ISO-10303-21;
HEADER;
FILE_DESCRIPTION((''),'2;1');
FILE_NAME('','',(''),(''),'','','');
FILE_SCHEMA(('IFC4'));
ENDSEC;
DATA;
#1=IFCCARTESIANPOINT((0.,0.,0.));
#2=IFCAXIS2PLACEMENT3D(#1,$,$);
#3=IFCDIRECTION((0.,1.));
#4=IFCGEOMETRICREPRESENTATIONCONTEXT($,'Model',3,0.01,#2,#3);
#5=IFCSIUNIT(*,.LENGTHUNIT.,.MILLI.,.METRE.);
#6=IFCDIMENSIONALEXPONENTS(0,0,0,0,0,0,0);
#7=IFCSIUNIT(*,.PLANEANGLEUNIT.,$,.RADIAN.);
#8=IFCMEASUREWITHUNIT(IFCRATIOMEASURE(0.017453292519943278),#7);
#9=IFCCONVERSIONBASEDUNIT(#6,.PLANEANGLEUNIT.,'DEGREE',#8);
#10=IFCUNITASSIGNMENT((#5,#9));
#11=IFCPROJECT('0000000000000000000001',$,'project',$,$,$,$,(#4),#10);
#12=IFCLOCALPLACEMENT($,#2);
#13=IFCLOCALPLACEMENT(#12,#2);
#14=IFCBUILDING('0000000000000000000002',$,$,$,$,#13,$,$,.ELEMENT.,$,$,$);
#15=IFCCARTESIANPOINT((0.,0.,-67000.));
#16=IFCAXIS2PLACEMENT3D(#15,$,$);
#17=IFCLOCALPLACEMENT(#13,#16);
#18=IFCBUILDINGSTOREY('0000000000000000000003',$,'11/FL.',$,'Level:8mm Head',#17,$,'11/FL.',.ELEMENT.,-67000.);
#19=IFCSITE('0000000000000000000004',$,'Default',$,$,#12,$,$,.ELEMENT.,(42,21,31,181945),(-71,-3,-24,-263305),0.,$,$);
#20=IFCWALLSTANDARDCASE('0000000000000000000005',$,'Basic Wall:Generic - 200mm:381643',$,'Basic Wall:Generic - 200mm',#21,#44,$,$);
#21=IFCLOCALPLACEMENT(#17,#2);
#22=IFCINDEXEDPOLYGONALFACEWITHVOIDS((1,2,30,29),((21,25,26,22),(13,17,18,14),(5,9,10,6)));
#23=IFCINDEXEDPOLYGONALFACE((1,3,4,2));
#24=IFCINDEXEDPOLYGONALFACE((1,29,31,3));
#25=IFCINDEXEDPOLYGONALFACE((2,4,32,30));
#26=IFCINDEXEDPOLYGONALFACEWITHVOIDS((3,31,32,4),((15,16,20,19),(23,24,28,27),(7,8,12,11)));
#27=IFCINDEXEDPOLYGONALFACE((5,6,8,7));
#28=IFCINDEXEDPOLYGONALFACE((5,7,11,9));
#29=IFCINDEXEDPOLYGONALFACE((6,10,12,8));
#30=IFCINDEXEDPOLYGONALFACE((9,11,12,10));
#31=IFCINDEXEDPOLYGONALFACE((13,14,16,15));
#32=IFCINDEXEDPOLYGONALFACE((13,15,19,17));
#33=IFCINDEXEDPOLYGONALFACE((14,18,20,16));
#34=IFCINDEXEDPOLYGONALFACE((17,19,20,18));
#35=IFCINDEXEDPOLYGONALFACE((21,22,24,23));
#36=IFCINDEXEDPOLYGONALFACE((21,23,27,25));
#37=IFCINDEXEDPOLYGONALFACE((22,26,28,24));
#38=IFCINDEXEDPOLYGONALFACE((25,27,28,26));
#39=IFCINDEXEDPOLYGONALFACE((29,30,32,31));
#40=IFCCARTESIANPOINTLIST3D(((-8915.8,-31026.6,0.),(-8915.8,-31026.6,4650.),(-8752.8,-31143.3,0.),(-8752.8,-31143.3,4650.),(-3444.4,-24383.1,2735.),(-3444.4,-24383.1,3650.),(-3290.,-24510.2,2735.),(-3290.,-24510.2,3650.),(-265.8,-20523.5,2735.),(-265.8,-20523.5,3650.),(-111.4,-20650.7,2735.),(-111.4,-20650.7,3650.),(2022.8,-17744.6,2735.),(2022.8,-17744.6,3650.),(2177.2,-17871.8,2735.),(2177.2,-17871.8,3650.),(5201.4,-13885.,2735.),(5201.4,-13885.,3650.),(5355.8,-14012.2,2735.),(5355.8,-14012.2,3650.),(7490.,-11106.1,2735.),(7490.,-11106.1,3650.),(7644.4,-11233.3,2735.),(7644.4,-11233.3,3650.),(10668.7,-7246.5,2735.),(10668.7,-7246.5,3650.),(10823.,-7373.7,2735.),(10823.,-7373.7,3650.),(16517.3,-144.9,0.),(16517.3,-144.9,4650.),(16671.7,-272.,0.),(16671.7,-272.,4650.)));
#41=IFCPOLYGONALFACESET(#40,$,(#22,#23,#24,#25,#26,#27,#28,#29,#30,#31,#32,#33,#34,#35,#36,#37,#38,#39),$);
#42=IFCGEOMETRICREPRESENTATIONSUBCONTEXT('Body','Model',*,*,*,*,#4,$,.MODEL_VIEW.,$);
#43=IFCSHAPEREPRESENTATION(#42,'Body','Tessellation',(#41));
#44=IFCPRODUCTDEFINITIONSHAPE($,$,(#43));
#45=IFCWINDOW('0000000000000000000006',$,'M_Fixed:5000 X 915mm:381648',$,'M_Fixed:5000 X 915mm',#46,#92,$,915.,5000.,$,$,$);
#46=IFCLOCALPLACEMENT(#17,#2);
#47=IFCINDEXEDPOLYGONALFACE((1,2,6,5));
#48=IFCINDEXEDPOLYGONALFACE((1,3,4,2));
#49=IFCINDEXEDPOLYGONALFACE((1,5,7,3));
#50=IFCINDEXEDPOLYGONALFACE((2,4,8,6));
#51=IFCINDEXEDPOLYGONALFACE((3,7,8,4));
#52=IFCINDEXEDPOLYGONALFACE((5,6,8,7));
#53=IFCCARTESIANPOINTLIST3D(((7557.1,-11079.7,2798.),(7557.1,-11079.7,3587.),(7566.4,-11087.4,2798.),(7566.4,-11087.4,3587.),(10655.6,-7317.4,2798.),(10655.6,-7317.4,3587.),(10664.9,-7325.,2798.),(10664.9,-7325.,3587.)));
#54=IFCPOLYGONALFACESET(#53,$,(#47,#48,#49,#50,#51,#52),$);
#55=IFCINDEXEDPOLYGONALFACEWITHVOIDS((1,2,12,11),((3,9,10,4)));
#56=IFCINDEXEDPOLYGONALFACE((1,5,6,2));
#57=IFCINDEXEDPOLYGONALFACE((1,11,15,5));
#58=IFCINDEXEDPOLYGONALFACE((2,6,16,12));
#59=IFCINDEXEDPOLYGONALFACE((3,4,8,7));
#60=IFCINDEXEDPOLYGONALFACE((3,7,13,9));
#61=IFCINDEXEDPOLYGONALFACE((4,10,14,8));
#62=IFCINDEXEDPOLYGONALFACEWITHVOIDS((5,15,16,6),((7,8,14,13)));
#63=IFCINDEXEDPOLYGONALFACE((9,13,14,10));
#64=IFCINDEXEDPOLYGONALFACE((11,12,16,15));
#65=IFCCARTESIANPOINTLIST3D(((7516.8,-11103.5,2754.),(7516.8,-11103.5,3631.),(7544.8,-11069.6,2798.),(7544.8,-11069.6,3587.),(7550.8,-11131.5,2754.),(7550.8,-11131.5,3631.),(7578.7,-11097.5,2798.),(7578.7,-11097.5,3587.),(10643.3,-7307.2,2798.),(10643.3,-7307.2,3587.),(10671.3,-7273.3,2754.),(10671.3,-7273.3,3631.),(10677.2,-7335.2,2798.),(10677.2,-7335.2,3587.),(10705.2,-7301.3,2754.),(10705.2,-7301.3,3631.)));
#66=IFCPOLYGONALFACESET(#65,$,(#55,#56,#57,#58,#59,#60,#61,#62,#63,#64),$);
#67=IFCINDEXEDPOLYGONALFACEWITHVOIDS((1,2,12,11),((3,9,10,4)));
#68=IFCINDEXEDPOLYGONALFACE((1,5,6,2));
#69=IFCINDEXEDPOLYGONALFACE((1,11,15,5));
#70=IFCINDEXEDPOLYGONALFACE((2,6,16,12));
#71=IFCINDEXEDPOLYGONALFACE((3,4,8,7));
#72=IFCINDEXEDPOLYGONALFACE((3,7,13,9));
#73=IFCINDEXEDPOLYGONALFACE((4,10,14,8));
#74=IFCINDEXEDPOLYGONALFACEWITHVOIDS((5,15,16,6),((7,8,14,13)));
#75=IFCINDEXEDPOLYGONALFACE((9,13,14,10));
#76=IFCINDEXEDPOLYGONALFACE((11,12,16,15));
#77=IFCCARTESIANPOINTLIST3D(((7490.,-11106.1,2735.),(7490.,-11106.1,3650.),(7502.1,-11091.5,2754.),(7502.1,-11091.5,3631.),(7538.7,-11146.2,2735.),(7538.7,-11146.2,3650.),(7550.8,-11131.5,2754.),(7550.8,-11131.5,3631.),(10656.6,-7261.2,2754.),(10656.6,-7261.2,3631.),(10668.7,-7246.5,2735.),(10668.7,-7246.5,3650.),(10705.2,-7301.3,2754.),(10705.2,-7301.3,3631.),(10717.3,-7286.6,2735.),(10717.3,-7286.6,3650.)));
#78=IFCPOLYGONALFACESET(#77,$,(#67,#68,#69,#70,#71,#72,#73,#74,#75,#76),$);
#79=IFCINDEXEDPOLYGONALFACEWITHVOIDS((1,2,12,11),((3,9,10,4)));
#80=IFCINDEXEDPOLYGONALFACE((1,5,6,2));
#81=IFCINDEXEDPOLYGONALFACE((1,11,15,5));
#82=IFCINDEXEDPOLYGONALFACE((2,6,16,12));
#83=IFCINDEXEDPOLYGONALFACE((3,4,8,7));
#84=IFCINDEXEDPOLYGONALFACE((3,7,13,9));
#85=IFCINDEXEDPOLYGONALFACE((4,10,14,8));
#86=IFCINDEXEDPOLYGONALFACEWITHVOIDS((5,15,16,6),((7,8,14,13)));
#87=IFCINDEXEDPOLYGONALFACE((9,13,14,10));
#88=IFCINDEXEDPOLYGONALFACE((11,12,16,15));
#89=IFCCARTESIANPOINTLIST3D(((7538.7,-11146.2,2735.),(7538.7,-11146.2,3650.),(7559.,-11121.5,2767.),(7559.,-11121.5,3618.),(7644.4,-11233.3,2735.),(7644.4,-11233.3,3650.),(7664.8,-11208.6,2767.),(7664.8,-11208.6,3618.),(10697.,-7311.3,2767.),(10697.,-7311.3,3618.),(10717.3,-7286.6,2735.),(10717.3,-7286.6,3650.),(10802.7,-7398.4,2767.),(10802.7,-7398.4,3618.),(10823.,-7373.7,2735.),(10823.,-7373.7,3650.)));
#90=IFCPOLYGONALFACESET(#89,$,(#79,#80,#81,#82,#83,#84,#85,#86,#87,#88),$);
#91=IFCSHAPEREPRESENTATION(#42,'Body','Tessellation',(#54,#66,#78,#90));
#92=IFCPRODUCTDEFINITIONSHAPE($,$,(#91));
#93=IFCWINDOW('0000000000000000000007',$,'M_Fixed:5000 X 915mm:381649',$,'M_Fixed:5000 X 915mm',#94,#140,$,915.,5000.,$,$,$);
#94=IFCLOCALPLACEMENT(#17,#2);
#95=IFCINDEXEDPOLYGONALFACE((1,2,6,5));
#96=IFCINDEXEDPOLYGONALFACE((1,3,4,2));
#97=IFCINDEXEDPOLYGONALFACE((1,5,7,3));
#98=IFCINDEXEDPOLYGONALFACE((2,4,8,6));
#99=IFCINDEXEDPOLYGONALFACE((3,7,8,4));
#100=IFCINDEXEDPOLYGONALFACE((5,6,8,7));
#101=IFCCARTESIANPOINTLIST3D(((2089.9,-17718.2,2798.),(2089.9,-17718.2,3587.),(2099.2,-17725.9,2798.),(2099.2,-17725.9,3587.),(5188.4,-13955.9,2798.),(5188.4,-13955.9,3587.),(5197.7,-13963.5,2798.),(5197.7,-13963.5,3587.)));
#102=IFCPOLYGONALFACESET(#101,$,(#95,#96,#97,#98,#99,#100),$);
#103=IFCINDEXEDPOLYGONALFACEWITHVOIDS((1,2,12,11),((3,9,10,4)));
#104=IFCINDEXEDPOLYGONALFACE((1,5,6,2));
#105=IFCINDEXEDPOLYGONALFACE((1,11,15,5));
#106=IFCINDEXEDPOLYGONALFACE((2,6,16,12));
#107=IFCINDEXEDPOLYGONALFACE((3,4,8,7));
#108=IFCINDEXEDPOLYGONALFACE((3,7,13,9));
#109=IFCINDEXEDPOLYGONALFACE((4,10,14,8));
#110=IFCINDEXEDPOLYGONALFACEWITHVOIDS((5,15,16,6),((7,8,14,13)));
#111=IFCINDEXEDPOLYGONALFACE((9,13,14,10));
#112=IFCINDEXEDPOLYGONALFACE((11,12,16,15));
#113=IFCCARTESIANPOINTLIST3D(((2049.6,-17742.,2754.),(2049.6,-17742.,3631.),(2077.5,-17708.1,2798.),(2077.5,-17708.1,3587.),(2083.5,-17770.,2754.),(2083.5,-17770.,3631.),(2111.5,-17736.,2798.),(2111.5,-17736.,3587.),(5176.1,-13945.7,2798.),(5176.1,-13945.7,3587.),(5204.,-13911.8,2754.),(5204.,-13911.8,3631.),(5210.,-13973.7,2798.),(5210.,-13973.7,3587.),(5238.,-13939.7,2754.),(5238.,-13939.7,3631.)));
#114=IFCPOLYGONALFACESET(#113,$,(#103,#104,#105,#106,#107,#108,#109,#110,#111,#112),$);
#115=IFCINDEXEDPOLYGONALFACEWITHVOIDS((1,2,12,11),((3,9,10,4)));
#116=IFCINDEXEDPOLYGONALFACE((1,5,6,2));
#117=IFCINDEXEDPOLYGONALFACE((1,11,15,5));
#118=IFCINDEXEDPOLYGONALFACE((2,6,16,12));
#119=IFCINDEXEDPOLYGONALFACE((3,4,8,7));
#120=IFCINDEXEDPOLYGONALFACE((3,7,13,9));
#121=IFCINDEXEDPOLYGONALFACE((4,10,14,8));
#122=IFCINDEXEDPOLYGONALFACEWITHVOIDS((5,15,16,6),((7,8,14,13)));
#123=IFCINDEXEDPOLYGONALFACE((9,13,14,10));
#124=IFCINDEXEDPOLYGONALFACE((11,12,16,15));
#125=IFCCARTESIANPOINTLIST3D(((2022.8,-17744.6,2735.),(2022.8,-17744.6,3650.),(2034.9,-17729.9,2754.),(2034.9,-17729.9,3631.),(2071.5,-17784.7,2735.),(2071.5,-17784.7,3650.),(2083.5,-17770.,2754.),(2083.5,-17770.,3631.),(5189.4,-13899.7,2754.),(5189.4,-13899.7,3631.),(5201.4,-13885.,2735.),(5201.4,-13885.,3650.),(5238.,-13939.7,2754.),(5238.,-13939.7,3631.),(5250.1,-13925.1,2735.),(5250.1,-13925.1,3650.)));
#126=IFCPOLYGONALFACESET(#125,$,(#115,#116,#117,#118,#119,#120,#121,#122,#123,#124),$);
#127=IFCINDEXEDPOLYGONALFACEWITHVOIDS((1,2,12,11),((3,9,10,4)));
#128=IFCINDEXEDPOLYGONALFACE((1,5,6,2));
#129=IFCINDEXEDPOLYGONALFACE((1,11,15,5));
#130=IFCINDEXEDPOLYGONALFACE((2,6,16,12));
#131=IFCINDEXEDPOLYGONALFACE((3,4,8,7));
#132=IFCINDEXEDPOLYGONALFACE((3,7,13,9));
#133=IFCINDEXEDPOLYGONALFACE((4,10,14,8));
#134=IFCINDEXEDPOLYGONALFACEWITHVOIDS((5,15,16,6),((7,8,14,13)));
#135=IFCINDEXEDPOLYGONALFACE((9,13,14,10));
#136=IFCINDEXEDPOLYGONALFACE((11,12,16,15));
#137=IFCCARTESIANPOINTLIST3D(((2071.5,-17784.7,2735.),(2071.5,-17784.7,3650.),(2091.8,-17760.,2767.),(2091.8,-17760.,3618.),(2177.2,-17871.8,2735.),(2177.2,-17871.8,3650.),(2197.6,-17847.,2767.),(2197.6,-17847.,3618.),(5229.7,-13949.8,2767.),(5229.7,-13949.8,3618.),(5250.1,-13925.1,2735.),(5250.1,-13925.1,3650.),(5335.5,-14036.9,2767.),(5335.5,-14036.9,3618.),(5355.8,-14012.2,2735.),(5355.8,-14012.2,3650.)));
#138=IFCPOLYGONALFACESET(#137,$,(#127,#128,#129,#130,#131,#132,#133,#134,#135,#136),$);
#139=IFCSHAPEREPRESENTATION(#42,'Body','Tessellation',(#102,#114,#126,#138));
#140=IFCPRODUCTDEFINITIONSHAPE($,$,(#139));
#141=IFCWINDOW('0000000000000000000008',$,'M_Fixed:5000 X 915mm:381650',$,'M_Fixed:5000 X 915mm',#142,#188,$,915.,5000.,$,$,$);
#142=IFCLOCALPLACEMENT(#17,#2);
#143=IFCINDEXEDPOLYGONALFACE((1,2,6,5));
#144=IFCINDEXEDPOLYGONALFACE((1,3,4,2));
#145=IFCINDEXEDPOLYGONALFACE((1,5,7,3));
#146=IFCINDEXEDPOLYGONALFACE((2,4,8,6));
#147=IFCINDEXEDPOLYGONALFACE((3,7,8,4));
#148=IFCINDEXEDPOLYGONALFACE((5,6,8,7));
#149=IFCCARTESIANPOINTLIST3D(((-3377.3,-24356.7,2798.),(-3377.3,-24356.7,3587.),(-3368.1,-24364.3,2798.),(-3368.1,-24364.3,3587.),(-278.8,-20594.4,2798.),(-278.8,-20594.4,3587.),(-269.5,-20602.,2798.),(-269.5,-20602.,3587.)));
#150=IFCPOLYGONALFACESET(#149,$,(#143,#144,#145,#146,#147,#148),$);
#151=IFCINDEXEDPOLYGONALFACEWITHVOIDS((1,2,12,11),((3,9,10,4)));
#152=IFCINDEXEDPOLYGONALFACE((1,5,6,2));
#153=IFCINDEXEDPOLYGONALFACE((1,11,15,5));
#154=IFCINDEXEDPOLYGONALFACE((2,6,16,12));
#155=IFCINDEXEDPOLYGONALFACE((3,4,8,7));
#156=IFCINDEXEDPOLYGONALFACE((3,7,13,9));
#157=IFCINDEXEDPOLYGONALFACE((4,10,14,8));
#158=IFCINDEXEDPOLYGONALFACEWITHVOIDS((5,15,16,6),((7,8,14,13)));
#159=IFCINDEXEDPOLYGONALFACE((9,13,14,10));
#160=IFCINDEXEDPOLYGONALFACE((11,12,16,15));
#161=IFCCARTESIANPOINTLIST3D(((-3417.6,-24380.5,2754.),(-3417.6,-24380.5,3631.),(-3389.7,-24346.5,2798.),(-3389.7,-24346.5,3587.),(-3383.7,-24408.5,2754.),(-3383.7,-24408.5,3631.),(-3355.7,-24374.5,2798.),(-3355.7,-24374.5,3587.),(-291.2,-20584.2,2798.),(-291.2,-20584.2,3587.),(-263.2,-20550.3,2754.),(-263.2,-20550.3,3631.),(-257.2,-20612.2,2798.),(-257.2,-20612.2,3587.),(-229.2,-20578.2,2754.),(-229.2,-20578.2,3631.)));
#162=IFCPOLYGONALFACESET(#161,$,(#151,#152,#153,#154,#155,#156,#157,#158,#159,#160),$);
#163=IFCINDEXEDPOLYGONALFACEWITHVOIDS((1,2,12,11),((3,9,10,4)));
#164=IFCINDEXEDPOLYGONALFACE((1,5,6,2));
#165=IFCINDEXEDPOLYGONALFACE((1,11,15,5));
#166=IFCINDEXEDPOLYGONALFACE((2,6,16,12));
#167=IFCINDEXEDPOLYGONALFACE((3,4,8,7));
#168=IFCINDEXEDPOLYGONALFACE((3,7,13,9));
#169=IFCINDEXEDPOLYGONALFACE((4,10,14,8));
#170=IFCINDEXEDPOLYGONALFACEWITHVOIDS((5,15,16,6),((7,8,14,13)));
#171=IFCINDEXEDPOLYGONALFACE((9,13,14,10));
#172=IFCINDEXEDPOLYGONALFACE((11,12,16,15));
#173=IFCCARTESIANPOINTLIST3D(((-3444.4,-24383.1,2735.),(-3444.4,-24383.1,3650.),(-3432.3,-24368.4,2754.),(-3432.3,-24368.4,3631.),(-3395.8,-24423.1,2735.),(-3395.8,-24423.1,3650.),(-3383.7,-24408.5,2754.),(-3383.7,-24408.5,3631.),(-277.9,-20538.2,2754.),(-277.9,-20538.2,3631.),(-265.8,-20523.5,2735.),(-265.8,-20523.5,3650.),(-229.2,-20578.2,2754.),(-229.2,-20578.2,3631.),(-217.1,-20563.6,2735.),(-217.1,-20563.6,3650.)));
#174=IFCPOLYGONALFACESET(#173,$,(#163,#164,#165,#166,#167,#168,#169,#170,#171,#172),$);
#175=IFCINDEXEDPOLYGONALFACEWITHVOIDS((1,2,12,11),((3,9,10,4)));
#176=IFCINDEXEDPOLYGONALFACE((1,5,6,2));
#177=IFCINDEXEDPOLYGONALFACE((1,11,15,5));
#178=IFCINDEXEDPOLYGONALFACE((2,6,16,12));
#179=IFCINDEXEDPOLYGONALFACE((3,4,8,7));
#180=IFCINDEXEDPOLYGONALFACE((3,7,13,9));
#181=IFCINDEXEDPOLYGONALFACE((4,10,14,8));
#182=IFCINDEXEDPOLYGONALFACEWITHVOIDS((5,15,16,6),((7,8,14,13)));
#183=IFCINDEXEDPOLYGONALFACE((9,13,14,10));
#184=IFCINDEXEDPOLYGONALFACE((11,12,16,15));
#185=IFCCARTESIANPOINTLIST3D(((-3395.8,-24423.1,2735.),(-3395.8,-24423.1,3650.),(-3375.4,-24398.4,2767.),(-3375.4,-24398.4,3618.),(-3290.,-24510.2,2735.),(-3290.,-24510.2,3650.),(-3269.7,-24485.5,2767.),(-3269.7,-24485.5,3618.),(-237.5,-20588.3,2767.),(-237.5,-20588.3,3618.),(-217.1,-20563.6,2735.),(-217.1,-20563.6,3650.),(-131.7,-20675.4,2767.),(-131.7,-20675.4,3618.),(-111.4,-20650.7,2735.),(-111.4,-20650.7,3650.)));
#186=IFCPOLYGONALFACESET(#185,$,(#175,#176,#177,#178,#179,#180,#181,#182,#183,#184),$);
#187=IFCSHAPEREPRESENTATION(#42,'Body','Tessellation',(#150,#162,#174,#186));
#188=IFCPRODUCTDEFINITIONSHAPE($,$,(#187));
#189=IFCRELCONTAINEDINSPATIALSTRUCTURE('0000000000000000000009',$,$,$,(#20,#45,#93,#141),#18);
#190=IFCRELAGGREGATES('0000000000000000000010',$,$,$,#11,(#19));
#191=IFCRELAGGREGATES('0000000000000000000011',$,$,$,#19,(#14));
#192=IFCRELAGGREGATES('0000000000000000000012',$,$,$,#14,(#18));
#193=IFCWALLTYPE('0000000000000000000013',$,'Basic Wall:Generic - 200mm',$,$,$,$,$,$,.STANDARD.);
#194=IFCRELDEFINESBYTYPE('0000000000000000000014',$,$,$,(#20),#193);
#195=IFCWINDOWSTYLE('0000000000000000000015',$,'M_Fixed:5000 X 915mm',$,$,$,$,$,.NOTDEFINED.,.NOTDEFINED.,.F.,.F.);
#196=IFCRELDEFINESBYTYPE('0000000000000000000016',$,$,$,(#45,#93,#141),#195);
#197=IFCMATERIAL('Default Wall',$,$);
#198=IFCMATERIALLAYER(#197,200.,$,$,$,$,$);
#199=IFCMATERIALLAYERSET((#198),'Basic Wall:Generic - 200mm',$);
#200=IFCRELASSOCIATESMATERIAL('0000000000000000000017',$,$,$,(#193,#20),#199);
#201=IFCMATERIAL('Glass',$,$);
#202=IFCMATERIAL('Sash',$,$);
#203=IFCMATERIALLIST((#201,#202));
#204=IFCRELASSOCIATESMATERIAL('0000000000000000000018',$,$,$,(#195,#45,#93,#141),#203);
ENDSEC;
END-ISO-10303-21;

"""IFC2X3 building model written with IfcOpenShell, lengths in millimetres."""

from ifc_helpers import new_model, entity, si_unit, converted_unit, direction, frame, frame_2d, origin, place, context, subcontext, project, spatial, polyline, rectangle, outline, extrude, source, transform, mapped, material, material_list, layer, layer_set, layer_usage, type_object, type_shapes, element, fill, save


model = new_model("IFC2X3")

# Units and contexts
model_context = context("Model", 3, precision=0.01, world=origin(), true_north=direction((0.0, 1.0)))
body_context = subcontext(model_context, "Body", "Model", "MODEL_VIEW")
ifc_project = project(units=[si_unit("LENGTHUNIT", "METRE", prefix="MILLI"), converted_unit("PLANEANGLEUNIT", "DEGREE", entity("IfcRatioMeasure", 0.017453292519943278), si_unit("PLANEANGLEUNIT", "RADIAN"), dimensions=[0, 0, 0, 0, 0, 0, 0])], contexts=[model_context])

# Site, building, storey
site_placement = place(None, origin())
site = spatial("IfcSite", under=ifc_project, at=site_placement, Name="Default", CompositionType="ELEMENT", RefLatitude=(42, 21, 31, 181945), RefLongitude=(-71, -3, -24, -263305), RefElevation=0.0)
building_placement = place(site_placement, origin())
building = spatial("IfcBuilding", under=site, at=building_placement, CompositionType="ELEMENT")
storey_placement = place(building_placement, frame((0.0, 0.0, -67000.0)))
storey = spatial("IfcBuildingStorey", under=building, at=storey_placement, Name="11/FL.", ObjectType="Level:8mm Head", LongName="11/FL.", CompositionType="ELEMENT", Elevation=-67000.0)

# Shared definitions
ifc_material_1 = material(Name="Default Wall")
ifc_layer = layer(ifc_material_1, 200.0)
ifc_layer_set = layer_set([ifc_layer], Name="Basic Wall:Generic - 200mm")
ifc_layer_usage = layer_usage(ifc_layer_set, "AXIS2", "NEGATIVE", 100.0)
wall_type = type_object("IfcWallType", Name="Basic Wall:Generic - 200mm", PredefinedType="STANDARD", material=ifc_layer_set)

# Wall, openings, windows
wall_1_placement = place(storey_placement, frame((17103.1, 409.1, 0.0), z_axis=(0.0, 0.0, 1.0), x_axis=(-0.635723, -0.771917, 0.0)))
wall_1 = element("IfcWallStandardCase", 1, at=wall_1_placement, inside=storey, type_object=wall_type, material=ifc_layer_usage, Name="Basic Wall:Generic - 200mm:381643", ObjectType="Basic Wall:Generic - 200mm", context=body_context, shape_type="SweptSolid", body=[
    extrude(outline(polyline([(40806.5, -100.0), (40793.0, 100.0), (37219.3, 100.0), (37019.3, 100.0), (800.0, 100.0), (800.0, -100.0), (37019.3, -100.0), (37219.3, -100.0), (40806.5, -100.0)])), origin(), (0.0, 0.0, 1.0), 4650.0),
])
opening_1_placement = place(wall_1_placement, origin())
element("IfcOpeningElement", 2, at=opening_1_placement, cuts=wall_1, ObjectType="Opening", context=body_context, shape_type="SweptSolid", body=[
    extrude(rectangle(XDim=1000.0, YDim=1012.7, at=frame_2d((0.0, 0.0), x_axis=(1.0, 0.0))), frame((293.7, -183.3, 500.0), z_axis=(0.0, 1.0, 0.0), x_axis=(0.0, 0.0, -1.0)), (0.0, 0.0, 1.0), 1010.1),
])
opening_2_placement = place(wall_1_placement, frame((15000.0, 100.0, 2735.0)))
opening_2 = element("IfcOpeningElement", 3, at=opening_2_placement, cuts=wall_1, ObjectType="Opening", context=body_context, shape_type="SweptSolid", body=[
    extrude(rectangle(XDim=915.0, YDim=5000.0, at=frame_2d((457.5, 2500.0), x_axis=(1.0, 0.0))), frame((0.0, 0.0, 0.0), z_axis=(0.0, -1.0, 0.0), x_axis=(0.0, 0.0, 1.0)), (0.0, 0.0, 1.0), 200.0),
])
opening_3_placement = place(wall_1_placement, frame((23600.0, 100.0, 2735.0)))
opening_3 = element("IfcOpeningElement", 4, at=opening_3_placement, cuts=wall_1, ObjectType="Opening", context=body_context, shape_type="SweptSolid", body=[
    extrude(rectangle(XDim=915.0, YDim=5000.0, at=frame_2d((457.5, 2500.0), x_axis=(1.0, 0.0))), frame((0.0, 0.0, 0.0), z_axis=(0.0, -1.0, 0.0), x_axis=(0.0, 0.0, 1.0)), (0.0, 0.0, 1.0), 200.0),
])
opening_4_placement = place(wall_1_placement, frame((32200.0, 100.0, 2735.0)))
opening_4 = element("IfcOpeningElement", 5, at=opening_4_placement, cuts=wall_1, ObjectType="Opening", context=body_context, shape_type="SweptSolid", body=[
    extrude(rectangle(XDim=915.0, YDim=5000.0, at=frame_2d((457.5, 2500.0), x_axis=(1.0, 0.0))), frame((0.0, 0.0, 0.0), z_axis=(0.0, -1.0, 0.0), x_axis=(0.0, 0.0, 1.0)), (0.0, 0.0, 1.0), 200.0),
])
ifc_material_2 = material(Name="Glass")
ifc_material_3 = material(Name="Sash")
ifc_material_list = material_list([ifc_material_2, ifc_material_3])
window_style_1 = type_object("IfcWindowStyle", Name="M_Fixed:5000 X 915mm", ConstructionType="NOTDEFINED", OperationType="NOTDEFINED", ParameterTakesPrecedence=False, Sizeable=False, material=ifc_material_list)
shared_shape_1 = source(origin(), body_context, "Body", "SweptSolid", [
    extrude(rectangle(XDim=12.0, YDim=4874.0, at=frame_2d((0.0, 0.0), x_axis=(1.0, 0.0))), frame((2500.0, 159.0, 63.0), z_axis=(0.0, 0.0, 1.0), x_axis=(0.0, -1.0, 0.0)), (0.0, 0.0, 1.0), 789.0),
    extrude(outline(polyline([(-2481.0, -438.5), (2481.0, -438.5), (2481.0, 438.5), (-2481.0, 438.5), (-2481.0, -438.5)]), holes=[polyline([(-2437.0, -394.5), (-2437.0, 394.5), (2437.0, 394.5), (2437.0, -394.5), (-2437.0, -394.5)])]), frame((2500.0, 137.0, 457.5), z_axis=(0.0, 1.0, 0.0), x_axis=(1.0, 0.0, 0.0)), (0.0, 0.0, 1.0), 44.0),
    extrude(outline(polyline([(-2500.0, -457.5), (2500.0, -457.5), (2500.0, 457.5), (-2500.0, 457.5), (-2500.0, -457.5)]), holes=[polyline([(-2481.0, -438.5), (-2481.0, 438.5), (2481.0, 438.5), (2481.0, -438.5), (-2481.0, -438.5)])]), frame((2500.0, 137.0, 457.5), z_axis=(0.0, 1.0, 0.0), x_axis=(1.0, 0.0, 0.0)), (0.0, 0.0, 1.0), 63.0),
    extrude(outline(polyline([(-2500.0, -457.5), (2500.0, -457.5), (2500.0, 457.5), (-2500.0, 457.5), (-2500.0, -457.5)]), holes=[polyline([(-2468.0, -425.5), (-2468.0, 425.5), (2468.0, 425.5), (2468.0, -425.5), (-2468.0, -425.5)])]), frame((2500.0, 0.0, 457.5), z_axis=(0.0, 1.0, 0.0), x_axis=(1.0, 0.0, 0.0)), (0.0, 0.0, 1.0), 137.0),
])
type_shapes(window_style_1, [shared_shape_1])
window_1_placement = place(opening_2_placement, frame((0.0, 0.0, 0.0), z_axis=(0.0, 0.0, 1.0), x_axis=(-1.0, 0.0, 0.0)))
window_1 = element("IfcWindow", 6, at=window_1_placement, inside=storey, type_object=window_style_1, material=ifc_material_list, Name="M_Fixed:5000 X 915mm:381648", ObjectType="M_Fixed:5000 X 915mm", OverallHeight=915.0, OverallWidth=5000.0, context=body_context, shape_type="MappedRepresentation", body=[
    mapped(shared_shape_1, transform((0.0, 0.0, 0.0), scale=1.0)),
])
fill(opening_2, window_1)
window_2_placement = place(opening_3_placement, frame((0.0, 0.0, 0.0), z_axis=(0.0, 0.0, 1.0), x_axis=(-1.0, 0.0, 0.0)))
window_2 = element("IfcWindow", 7, at=window_2_placement, inside=storey, type_object=window_style_1, material=ifc_material_list, Name="M_Fixed:5000 X 915mm:381649", ObjectType="M_Fixed:5000 X 915mm", OverallHeight=915.0, OverallWidth=5000.0, context=body_context, shape_type="MappedRepresentation", body=[
    mapped(shared_shape_1, transform((0.0, 0.0, 0.0), scale=1.0)),
])
fill(opening_3, window_2)
window_3_placement = place(opening_4_placement, frame((0.0, 0.0, 0.0), z_axis=(0.0, 0.0, 1.0), x_axis=(-1.0, 0.0, 0.0)))
window_3 = element("IfcWindow", 8, at=window_3_placement, inside=storey, type_object=window_style_1, material=ifc_material_list, Name="M_Fixed:5000 X 915mm:381650", ObjectType="M_Fixed:5000 X 915mm", OverallHeight=915.0, OverallWidth=5000.0, context=body_context, shape_type="MappedRepresentation", body=[
    mapped(shared_shape_1, transform((0.0, 0.0, 0.0), scale=1.0)),
])
fill(opening_4, window_3)

save(model, "model.ifc")
